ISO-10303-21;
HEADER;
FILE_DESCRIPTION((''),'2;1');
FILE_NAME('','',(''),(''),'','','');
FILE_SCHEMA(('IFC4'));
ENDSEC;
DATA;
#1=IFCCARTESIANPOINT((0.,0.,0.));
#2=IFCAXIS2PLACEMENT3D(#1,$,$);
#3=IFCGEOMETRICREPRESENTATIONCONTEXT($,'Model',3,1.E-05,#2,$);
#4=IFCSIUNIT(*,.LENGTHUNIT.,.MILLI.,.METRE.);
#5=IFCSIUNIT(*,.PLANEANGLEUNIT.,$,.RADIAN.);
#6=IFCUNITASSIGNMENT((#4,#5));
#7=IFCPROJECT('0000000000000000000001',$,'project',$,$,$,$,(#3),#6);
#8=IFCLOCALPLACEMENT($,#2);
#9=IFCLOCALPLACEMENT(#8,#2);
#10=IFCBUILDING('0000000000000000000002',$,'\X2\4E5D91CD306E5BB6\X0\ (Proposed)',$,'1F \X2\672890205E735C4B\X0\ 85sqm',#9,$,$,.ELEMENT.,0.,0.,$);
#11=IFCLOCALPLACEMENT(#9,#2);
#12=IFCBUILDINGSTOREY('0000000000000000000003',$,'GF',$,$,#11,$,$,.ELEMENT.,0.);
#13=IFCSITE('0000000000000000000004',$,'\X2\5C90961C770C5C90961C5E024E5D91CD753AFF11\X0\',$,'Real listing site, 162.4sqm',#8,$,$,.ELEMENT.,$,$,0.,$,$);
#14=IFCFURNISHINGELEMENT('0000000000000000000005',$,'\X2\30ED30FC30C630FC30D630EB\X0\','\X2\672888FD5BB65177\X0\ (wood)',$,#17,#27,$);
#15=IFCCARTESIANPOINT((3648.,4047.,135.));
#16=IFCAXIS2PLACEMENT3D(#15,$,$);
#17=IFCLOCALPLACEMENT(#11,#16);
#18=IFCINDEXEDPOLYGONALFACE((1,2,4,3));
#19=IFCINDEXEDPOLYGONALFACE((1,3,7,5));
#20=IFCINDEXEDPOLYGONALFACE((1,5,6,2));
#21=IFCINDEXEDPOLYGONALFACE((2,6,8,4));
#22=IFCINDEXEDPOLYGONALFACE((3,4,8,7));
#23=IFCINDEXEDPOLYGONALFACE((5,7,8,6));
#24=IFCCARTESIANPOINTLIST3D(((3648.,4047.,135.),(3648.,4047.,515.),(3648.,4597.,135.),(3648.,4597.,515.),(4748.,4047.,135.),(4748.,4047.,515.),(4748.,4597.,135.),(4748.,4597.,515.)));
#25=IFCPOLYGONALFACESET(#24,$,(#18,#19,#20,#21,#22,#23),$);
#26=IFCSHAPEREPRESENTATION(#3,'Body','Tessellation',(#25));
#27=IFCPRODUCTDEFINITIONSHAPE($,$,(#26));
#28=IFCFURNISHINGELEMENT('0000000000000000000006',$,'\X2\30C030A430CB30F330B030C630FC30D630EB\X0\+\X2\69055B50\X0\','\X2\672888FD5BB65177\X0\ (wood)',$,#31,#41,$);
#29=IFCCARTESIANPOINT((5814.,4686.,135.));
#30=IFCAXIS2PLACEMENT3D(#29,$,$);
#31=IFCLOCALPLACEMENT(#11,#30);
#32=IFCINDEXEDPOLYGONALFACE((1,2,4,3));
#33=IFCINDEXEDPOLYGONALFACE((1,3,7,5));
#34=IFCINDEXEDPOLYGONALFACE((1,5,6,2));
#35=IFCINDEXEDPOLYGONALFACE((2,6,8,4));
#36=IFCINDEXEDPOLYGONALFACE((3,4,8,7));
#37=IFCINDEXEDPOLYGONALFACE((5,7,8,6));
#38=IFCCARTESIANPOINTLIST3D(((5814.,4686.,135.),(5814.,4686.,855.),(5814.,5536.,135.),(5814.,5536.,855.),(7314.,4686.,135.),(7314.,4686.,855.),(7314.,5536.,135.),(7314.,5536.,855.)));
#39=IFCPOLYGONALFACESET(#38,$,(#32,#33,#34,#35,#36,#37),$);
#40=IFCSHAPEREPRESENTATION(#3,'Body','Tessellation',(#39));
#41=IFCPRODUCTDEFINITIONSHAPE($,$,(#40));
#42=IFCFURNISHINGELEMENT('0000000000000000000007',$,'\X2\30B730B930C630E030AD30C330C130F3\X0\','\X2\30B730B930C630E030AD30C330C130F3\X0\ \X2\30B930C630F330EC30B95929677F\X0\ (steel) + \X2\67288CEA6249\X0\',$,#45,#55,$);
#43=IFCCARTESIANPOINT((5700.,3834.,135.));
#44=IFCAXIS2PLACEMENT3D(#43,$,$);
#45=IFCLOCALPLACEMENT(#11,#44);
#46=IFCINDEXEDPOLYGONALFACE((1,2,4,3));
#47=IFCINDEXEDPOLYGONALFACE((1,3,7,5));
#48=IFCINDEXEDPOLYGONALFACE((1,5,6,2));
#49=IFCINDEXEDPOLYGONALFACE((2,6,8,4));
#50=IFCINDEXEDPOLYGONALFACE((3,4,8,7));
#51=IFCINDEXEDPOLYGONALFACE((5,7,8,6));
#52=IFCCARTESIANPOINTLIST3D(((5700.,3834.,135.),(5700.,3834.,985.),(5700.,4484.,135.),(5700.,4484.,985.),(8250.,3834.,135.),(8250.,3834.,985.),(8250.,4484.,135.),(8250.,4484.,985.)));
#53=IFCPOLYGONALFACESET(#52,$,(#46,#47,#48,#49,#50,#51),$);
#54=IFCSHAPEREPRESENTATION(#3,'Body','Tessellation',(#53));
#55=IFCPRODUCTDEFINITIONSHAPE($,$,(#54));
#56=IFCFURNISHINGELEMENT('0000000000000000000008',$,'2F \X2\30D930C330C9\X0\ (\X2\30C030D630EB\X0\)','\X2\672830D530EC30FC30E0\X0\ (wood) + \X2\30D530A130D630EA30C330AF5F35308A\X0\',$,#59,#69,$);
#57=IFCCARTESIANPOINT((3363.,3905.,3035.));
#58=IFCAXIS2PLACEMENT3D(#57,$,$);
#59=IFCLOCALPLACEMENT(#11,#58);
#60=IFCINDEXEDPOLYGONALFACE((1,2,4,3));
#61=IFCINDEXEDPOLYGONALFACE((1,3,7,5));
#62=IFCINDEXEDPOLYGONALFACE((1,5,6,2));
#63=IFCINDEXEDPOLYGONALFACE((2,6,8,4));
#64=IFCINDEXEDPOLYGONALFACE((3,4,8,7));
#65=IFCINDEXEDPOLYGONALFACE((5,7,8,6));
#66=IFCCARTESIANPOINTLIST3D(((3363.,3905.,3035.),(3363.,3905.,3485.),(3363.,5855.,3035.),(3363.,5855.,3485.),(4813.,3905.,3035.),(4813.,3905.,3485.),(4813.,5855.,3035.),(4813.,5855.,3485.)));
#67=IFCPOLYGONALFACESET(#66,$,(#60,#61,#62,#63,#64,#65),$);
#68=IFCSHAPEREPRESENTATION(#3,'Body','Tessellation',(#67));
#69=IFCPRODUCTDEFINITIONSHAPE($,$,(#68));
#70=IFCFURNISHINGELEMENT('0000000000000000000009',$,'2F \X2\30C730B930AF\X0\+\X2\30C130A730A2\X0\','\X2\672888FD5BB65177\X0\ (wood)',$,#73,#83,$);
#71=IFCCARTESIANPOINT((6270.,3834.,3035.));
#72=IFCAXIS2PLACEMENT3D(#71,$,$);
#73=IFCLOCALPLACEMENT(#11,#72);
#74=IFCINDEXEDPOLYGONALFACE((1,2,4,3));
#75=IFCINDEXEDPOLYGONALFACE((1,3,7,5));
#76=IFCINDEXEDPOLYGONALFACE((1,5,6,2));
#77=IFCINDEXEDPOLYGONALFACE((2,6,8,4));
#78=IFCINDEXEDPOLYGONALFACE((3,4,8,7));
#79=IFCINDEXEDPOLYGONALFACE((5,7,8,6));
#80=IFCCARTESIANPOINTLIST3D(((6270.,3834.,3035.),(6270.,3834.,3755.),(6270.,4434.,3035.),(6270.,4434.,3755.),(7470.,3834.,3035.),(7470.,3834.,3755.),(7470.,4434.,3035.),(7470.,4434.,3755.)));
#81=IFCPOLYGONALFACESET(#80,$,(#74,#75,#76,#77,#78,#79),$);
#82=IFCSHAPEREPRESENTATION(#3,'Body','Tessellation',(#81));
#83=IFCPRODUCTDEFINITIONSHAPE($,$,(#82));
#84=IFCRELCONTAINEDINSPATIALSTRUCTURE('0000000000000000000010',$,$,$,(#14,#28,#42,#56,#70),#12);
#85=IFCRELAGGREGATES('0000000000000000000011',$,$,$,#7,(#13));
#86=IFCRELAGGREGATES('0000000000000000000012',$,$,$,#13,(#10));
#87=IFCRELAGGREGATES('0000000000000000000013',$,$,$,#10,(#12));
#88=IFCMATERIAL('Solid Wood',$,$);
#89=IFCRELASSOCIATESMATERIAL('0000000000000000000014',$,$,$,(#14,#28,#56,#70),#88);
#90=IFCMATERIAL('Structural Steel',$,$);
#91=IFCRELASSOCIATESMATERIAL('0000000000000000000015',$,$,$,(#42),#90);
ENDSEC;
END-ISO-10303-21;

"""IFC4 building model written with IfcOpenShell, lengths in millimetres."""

from ifc_helpers import new_model, si_unit, frame, frame_2d, origin, place, context, project, spatial, rectangle, extrude, material, element, save


model = new_model("IFC4")

# Units and contexts
model_context = context("Model", 3, precision=1e-05, world=origin())
ifc_project = project(units=[si_unit("LENGTHUNIT", "METRE", prefix="MILLI"), si_unit("PLANEANGLEUNIT", "RADIAN")], contexts=[model_context])

# Site, building, storey
site_placement = place(None, origin())
site = spatial("IfcSite", under=ifc_project, at=site_placement, Name="岐阜県岐阜市九重町１", ObjectType="Real listing site, 162.4sqm", CompositionType="ELEMENT", RefElevation=0.0)
building_placement = place(site_placement, origin())
building = spatial("IfcBuilding", under=site, at=building_placement, Name="九重の家 (Proposed)", ObjectType="1F 木造平屋 85sqm", CompositionType="ELEMENT", ElevationOfRefHeight=0.0, ElevationOfTerrain=0.0)
storey_placement = place(building_placement, origin())
storey = spatial("IfcBuildingStorey", under=building, at=storey_placement, Name="GF", CompositionType="ELEMENT", Elevation=0.0)

# Shared definitions
ifc_material_1 = material(Name="Solid Wood")

# Shared definitions
ifc_material_2 = material(Name="Structural Steel")

# Furnishing elements
furnishing_1_placement = place(storey_placement, frame((3648.0, 4047.0, 135.0)))
element("IfcFurnishingElement", 1, at=furnishing_1_placement, inside=storey, material=ifc_material_1, Name="ローテーブル", Description="木製家具 (wood)", context=model_context, shape_type="SweptSolid", body=[
    extrude(rectangle(XDim=1100.0, YDim=550.0, at=frame_2d((550.0, 275.0))), frame((3648.0, 4047.0, 135.0)), (0.0, 0.0, 1.0), 380.0),
])
furnishing_2_placement = place(storey_placement, frame((5814.0, 4686.0, 135.0)))
element("IfcFurnishingElement", 2, at=furnishing_2_placement, inside=storey, material=ifc_material_1, Name="ダイニングテーブル+椅子", Description="木製家具 (wood)", context=model_context, shape_type="SweptSolid", body=[
    extrude(rectangle(XDim=1500.0, YDim=850.0, at=frame_2d((750.0, 425.0))), frame((5814.0, 4686.0, 135.0)), (0.0, 0.0, 1.0), 720.0),
])
furnishing_3_placement = place(storey_placement, frame((5700.0, 3834.0, 135.0)))
element("IfcFurnishingElement", 3, at=furnishing_3_placement, inside=storey, material=ifc_material_2, Name="システムキッチン", Description="システムキッチン ステンレス天板 (steel) + 木質扉", context=model_context, shape_type="SweptSolid", body=[
    extrude(rectangle(XDim=2550.0, YDim=650.0, at=frame_2d((1275.0, 325.0))), frame((5700.0, 3834.0, 135.0)), (0.0, 0.0, 1.0), 850.0),
])
furnishing_4_placement = place(storey_placement, frame((3363.0, 3905.0, 3035.0)))
element("IfcFurnishingElement", 4, at=furnishing_4_placement, inside=storey, material=ifc_material_1, Name="2F ベッド (ダブル)", Description="木フレーム (wood) + ファブリック張り", context=model_context, shape_type="SweptSolid", body=[
    extrude(rectangle(XDim=1450.0, YDim=1950.0, at=frame_2d((725.0, 975.0))), frame((3363.0, 3905.0, 3035.0)), (0.0, 0.0, 1.0), 450.0),
])
furnishing_5_placement = place(storey_placement, frame((6270.0, 3834.0, 3035.0)))
element("IfcFurnishingElement", 5, at=furnishing_5_placement, inside=storey, material=ifc_material_1, Name="2F デスク+チェア", Description="木製家具 (wood)", context=model_context, shape_type="SweptSolid", body=[
    extrude(rectangle(XDim=1200.0, YDim=600.0, at=frame_2d((600.0, 300.0))), frame((6270.0, 3834.0, 3035.0)), (0.0, 0.0, 1.0), 720.0),
])

save(model, "model.ifc")
